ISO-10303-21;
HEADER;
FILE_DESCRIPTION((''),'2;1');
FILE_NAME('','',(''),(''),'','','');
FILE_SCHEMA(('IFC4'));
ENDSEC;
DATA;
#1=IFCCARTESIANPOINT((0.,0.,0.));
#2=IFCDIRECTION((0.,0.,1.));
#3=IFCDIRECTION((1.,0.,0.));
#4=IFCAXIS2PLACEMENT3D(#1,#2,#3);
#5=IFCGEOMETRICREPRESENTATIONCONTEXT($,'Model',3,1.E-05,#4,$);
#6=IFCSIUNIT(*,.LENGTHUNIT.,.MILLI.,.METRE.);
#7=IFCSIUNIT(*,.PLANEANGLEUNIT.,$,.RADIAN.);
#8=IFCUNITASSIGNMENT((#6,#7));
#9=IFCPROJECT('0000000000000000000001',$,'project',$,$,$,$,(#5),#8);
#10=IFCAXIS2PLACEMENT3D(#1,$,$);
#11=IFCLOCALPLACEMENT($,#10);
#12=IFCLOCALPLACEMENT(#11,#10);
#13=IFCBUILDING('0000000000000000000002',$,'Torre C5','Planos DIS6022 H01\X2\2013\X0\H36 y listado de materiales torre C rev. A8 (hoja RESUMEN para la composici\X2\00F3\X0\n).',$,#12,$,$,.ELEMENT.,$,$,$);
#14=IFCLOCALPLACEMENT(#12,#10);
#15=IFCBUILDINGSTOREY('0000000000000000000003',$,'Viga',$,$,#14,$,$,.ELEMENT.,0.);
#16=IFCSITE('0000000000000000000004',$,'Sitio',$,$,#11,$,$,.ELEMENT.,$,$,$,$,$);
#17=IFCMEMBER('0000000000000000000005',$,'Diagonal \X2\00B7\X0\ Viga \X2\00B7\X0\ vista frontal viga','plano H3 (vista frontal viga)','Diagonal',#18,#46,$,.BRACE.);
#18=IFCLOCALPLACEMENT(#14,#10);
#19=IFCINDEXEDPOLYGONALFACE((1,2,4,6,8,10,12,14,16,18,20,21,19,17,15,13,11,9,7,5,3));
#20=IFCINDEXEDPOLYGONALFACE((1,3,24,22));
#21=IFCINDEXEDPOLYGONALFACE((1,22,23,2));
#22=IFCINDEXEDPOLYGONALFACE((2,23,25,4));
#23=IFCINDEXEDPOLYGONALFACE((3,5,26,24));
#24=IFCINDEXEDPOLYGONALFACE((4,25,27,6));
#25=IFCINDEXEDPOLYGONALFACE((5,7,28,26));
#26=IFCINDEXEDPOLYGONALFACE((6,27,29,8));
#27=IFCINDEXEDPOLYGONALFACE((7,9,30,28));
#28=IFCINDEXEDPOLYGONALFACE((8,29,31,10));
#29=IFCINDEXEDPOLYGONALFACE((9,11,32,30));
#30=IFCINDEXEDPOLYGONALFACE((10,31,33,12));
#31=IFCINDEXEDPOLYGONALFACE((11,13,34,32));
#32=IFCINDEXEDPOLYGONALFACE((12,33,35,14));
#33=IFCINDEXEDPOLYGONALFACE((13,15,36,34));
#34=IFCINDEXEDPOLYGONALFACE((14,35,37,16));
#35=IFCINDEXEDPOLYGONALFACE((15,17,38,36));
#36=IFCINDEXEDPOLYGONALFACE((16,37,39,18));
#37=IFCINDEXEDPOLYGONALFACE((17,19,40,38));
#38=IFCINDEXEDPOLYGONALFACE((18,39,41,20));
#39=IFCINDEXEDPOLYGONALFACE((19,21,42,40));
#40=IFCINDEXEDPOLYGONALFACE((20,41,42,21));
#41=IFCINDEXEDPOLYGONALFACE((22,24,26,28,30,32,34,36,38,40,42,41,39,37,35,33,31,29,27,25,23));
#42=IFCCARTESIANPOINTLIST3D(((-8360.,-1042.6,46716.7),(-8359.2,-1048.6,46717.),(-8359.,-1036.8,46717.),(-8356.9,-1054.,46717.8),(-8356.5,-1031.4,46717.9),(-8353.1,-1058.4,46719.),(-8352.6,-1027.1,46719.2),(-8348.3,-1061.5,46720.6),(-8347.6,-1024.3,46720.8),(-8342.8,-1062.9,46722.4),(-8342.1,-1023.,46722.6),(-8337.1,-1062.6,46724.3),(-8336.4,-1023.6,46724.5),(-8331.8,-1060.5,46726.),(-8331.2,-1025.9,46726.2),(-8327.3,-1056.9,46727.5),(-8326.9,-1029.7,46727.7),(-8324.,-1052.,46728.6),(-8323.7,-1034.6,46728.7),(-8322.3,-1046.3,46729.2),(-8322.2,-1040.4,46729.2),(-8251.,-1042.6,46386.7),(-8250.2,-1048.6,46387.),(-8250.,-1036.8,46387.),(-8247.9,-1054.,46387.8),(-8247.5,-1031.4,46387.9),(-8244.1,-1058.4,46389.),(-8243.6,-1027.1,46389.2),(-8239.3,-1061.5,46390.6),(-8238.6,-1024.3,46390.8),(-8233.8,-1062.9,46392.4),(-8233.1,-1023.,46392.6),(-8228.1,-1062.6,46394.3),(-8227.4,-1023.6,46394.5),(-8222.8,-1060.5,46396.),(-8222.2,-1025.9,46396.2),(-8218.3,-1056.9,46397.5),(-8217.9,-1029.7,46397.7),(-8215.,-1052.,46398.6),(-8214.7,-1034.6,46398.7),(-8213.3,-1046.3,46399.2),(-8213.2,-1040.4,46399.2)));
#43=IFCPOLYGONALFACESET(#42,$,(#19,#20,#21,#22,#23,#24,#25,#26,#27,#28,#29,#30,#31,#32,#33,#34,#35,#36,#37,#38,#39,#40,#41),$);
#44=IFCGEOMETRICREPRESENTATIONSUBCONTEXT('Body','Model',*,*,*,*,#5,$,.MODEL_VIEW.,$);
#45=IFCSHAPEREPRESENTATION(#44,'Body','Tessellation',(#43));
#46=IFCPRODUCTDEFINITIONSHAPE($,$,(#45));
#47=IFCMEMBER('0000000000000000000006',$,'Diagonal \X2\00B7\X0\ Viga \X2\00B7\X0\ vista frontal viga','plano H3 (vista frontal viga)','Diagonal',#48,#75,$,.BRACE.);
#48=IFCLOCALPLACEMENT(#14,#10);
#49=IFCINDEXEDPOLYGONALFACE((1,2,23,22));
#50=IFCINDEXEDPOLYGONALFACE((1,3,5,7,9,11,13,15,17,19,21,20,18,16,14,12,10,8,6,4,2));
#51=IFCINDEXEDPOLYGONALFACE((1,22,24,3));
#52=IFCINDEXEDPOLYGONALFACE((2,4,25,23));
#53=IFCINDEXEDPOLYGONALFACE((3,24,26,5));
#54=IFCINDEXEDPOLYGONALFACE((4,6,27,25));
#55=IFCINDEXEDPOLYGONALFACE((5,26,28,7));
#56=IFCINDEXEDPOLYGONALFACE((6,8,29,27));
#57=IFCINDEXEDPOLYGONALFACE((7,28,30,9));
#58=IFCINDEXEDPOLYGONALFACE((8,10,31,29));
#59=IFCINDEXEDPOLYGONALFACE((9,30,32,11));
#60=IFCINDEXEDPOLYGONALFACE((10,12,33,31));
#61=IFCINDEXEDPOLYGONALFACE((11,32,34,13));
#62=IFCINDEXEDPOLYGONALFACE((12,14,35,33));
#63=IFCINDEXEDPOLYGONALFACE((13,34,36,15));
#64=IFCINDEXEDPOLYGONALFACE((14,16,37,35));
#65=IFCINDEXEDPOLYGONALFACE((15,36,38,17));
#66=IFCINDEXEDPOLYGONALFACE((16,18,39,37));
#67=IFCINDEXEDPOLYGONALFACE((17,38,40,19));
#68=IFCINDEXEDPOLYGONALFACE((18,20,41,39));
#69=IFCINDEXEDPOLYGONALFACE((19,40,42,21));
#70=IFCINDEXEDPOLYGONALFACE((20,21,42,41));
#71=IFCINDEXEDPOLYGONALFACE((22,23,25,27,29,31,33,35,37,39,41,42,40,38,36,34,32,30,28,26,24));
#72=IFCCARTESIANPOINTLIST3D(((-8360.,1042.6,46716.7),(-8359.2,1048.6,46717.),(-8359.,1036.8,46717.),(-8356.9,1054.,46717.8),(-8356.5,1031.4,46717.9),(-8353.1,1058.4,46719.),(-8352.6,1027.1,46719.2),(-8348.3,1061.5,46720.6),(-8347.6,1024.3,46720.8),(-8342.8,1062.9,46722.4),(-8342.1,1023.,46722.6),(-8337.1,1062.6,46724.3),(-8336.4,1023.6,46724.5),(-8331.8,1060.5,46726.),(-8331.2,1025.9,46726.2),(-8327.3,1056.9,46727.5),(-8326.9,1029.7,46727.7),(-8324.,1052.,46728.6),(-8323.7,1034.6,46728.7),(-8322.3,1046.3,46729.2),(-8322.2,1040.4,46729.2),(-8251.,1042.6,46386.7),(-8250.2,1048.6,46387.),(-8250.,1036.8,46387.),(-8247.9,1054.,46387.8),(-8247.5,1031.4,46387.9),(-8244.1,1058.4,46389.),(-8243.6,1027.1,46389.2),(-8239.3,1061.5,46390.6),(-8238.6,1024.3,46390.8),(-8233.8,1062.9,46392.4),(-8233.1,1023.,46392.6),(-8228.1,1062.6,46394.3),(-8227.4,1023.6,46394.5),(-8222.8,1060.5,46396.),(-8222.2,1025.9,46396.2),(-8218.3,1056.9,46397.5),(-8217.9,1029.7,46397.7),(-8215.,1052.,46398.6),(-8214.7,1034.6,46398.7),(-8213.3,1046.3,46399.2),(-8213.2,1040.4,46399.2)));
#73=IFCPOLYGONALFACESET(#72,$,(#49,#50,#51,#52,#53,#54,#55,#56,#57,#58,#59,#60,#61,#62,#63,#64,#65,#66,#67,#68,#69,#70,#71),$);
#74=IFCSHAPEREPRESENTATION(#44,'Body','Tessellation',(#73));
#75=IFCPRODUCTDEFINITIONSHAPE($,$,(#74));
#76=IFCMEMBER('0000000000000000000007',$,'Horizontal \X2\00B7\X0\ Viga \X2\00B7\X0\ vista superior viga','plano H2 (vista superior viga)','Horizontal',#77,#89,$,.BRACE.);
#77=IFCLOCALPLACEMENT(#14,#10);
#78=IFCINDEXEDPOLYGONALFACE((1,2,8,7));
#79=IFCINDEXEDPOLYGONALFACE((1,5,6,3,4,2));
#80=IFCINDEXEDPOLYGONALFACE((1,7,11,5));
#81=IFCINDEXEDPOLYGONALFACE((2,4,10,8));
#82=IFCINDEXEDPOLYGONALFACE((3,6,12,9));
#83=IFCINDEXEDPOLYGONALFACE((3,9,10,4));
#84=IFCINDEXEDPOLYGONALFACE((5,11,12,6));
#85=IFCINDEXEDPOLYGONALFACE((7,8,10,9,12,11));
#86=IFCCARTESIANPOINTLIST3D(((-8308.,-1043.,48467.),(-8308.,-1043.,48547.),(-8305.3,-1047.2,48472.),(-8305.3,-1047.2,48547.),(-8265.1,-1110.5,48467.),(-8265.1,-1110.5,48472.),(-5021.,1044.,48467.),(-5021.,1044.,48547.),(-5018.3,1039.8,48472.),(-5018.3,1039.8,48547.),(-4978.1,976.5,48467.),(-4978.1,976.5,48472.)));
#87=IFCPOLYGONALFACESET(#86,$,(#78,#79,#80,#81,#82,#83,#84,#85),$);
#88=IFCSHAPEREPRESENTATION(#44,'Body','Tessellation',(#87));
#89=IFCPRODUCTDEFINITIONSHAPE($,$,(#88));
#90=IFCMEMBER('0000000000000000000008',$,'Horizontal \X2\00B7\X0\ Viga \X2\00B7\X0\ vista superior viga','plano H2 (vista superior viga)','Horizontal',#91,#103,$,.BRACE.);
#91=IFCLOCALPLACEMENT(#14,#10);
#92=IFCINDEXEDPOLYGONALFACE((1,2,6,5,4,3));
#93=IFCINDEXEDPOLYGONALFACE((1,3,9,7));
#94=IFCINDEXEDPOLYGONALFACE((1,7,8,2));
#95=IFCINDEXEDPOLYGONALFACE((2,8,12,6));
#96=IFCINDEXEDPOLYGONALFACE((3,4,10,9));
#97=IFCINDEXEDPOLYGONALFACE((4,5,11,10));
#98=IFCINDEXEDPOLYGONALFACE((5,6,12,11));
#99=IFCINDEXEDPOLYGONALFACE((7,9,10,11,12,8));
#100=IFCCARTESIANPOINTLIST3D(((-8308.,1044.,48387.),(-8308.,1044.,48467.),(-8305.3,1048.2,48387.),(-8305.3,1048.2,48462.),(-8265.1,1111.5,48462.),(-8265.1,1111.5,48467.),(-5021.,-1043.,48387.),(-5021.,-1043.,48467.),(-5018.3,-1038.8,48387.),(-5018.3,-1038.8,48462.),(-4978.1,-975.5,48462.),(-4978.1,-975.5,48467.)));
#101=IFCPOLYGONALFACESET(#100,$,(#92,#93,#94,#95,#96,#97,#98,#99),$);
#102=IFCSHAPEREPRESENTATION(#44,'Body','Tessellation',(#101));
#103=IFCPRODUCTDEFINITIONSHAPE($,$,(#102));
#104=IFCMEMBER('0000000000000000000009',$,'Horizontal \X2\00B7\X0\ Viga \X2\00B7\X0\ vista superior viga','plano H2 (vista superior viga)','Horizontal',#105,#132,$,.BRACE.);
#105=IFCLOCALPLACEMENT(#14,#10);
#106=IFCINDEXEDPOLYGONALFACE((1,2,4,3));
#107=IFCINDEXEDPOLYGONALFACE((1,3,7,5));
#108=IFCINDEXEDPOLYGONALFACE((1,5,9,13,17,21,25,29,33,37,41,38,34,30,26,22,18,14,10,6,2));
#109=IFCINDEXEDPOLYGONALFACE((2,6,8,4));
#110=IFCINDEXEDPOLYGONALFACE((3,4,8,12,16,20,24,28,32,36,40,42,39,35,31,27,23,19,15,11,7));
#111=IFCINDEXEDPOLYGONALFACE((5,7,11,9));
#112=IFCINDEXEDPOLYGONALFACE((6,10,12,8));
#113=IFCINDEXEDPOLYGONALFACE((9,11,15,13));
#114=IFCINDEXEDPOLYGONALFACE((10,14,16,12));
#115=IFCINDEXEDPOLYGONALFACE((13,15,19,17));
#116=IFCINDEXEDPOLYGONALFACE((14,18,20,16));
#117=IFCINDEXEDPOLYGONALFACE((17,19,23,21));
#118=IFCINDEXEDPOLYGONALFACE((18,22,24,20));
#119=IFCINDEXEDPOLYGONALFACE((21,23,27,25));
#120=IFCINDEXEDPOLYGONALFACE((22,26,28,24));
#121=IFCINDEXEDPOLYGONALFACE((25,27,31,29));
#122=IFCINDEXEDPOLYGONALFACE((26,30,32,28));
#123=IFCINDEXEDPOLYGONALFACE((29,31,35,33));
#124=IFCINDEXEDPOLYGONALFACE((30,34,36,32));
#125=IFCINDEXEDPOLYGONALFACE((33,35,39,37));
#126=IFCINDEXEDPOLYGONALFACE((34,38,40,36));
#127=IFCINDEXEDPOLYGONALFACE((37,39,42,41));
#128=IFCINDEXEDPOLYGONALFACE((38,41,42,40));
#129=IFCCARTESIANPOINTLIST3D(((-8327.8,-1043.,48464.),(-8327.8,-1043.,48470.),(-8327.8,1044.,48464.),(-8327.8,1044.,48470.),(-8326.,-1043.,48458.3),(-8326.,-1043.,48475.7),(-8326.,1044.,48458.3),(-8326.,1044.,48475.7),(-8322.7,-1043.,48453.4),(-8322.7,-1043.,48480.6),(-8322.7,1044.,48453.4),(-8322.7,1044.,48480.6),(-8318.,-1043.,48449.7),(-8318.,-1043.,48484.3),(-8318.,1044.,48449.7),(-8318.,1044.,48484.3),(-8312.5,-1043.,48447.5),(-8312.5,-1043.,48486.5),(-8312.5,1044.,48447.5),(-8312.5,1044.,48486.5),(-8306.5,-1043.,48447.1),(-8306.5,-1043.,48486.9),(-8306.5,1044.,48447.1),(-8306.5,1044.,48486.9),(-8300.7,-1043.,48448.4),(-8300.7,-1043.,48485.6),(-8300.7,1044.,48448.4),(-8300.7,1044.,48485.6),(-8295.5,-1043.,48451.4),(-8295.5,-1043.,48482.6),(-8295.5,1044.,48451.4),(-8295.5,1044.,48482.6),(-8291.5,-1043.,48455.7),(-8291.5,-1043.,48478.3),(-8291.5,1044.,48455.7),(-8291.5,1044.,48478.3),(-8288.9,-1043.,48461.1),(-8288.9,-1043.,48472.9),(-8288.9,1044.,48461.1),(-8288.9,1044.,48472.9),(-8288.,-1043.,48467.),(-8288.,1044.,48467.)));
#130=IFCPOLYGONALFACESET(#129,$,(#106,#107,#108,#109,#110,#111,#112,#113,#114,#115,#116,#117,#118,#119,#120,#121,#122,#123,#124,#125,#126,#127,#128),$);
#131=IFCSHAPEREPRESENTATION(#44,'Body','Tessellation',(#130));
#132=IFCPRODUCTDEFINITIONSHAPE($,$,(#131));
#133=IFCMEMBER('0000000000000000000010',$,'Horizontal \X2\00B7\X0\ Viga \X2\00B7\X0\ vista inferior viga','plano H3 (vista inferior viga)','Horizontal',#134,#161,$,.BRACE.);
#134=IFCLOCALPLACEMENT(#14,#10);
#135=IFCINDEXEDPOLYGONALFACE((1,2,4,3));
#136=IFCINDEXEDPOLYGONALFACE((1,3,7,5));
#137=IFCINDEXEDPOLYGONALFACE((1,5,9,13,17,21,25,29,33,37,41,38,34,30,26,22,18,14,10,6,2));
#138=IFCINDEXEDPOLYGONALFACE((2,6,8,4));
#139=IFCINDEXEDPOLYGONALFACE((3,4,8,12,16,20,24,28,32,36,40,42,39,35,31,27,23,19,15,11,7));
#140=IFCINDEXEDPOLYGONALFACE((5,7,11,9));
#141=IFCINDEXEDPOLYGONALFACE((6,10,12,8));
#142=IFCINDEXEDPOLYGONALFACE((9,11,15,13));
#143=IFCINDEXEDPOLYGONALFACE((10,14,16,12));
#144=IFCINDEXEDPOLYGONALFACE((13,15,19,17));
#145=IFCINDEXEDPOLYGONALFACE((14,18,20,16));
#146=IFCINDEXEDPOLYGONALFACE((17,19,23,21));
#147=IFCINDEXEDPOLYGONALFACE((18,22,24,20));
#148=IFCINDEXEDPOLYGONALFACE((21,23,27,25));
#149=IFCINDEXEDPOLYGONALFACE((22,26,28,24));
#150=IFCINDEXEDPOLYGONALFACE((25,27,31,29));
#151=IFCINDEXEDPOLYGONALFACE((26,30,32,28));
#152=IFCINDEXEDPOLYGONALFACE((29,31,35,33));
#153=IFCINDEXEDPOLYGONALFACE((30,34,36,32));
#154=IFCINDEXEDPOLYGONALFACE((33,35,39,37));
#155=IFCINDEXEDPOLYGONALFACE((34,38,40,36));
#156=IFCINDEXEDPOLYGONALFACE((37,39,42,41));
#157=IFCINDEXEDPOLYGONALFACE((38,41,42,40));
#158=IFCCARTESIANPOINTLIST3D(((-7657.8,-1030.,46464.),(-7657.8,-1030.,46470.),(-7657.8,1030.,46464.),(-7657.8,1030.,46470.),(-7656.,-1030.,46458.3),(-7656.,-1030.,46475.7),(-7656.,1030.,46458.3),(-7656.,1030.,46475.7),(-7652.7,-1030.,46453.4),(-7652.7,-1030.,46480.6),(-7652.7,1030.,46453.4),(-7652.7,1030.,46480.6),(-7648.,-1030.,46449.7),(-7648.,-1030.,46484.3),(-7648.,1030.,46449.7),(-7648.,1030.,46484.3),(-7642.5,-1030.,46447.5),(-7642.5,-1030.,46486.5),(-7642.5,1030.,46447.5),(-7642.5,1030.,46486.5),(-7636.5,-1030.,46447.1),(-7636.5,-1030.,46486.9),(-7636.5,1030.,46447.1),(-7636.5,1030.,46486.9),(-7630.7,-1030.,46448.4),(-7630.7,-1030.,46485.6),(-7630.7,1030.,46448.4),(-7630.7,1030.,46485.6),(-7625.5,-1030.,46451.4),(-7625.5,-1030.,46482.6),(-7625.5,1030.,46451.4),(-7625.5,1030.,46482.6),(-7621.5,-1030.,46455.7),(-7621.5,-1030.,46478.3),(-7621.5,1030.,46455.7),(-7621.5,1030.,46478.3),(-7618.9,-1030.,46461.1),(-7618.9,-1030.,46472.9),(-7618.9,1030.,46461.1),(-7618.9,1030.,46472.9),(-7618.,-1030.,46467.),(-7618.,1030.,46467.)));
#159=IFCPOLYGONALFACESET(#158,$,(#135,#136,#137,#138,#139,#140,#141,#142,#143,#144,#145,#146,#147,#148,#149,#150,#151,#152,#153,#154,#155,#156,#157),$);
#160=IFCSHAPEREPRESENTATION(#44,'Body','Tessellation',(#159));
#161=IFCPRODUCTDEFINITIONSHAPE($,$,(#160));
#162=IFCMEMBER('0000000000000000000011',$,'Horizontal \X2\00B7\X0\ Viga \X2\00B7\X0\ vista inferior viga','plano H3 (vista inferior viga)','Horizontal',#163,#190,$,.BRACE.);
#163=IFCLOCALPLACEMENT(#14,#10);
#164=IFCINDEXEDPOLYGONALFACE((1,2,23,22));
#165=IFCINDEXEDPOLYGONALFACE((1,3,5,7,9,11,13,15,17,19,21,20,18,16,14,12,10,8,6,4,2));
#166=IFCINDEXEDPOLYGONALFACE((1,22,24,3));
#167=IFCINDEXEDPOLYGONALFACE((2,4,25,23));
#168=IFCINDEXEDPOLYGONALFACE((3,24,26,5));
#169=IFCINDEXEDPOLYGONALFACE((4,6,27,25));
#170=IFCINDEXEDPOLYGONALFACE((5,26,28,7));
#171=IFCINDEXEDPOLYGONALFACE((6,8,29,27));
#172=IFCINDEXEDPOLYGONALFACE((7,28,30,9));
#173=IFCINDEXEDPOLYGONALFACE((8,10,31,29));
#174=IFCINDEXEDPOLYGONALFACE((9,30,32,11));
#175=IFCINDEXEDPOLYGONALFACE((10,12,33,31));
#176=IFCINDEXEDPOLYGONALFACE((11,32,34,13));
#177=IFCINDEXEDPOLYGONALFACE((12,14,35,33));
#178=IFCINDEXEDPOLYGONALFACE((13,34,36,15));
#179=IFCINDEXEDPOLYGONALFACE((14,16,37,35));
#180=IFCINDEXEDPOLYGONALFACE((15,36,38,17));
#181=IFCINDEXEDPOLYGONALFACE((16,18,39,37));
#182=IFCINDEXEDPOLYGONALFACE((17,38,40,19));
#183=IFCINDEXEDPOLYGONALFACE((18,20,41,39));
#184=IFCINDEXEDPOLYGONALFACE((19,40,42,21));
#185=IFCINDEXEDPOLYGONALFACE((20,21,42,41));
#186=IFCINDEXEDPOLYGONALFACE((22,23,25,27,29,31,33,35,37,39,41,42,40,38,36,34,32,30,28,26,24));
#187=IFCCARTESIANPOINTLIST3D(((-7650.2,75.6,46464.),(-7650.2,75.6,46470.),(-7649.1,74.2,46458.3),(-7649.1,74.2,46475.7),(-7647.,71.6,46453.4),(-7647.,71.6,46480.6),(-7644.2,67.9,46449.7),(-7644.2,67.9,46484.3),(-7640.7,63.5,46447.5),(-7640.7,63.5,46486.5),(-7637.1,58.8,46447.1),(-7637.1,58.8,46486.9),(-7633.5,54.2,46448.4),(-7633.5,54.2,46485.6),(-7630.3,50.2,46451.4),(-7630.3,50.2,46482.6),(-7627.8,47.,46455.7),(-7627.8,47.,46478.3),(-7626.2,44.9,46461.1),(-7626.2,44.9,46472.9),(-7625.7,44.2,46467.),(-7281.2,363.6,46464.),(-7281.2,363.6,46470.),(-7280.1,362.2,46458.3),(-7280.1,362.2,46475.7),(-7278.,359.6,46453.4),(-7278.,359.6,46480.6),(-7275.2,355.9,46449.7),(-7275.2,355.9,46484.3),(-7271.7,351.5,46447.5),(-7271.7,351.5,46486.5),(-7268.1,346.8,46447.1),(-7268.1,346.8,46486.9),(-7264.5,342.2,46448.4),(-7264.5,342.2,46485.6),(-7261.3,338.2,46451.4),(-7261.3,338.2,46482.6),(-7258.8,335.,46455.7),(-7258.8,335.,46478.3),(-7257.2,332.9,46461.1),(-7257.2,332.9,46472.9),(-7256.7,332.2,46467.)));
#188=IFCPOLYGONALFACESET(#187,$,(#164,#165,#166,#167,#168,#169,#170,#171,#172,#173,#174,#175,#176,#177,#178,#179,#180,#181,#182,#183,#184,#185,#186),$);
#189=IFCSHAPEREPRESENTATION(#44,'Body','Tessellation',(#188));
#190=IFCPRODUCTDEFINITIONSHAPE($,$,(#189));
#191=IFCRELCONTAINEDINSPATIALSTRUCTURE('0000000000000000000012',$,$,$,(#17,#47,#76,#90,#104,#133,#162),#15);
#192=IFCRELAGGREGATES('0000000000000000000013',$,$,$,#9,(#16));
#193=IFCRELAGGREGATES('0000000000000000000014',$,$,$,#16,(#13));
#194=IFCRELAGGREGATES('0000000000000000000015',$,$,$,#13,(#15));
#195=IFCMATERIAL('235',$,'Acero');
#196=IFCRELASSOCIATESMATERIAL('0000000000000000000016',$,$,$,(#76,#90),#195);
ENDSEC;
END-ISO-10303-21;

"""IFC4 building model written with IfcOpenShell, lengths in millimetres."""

from ifc_helpers import new_model, si_unit, frame, frame_2d, origin, origin_with_axes, place, context, subcontext, project, spatial, circle, l_section, extrude, material, element, save


model = new_model("IFC4")

# Units and contexts
model_context = context("Model", 3, precision=1e-05, world=origin_with_axes())
body_context = subcontext(model_context, "Body", "Model", "MODEL_VIEW")
ifc_project = project(units=[si_unit("LENGTHUNIT", "METRE", prefix="MILLI"), si_unit("PLANEANGLEUNIT", "RADIAN")], contexts=[model_context])

# Site, building, storey
site_placement = place(None, origin())
site = spatial("IfcSite", under=ifc_project, at=site_placement, Name="Sitio", CompositionType="ELEMENT")
building_placement = place(site_placement, origin())
building = spatial("IfcBuilding", under=site, at=building_placement, Name="Torre C5", Description="Planos DIS6022 H01–H36 y listado de materiales torre C rev. A8 (hoja RESUMEN para la composición).", CompositionType="ELEMENT")
storey_placement = place(building_placement, origin())
storey = spatial("IfcBuildingStorey", under=building, at=storey_placement, Name="Viga", CompositionType="ELEMENT", Elevation=0.0)

# Members
ifc_material_1 = material(Name="235", Category="Acero")
for number, where, z_axis, x_axis, name in (
    (1, (-8232.0, -1043.0, 46393.0), (-0.313637, 0.0, 0.949543), (0.941309, 0.131406, 0.310917), "Diagonal · Viga · vista frontal viga"),
    (2, (-8232.0, 1043.0, 46393.0), (-0.313637, 0.0, 0.949543), (0.941309, -0.131406, 0.310917), "Diagonal · Viga · vista frontal viga"),
):
    element("IfcMember", number, at=place(storey_placement, frame(where, z_axis=z_axis, x_axis=x_axis)), inside=storey, Name=name, Description="plano H3 (vista frontal viga)", ObjectType="Diagonal", PredefinedType="BRACE", context=body_context, shape_type="SweptSolid", body=[
        extrude(circle(Radius=20.0), None, (0.0, 0.0, 1.0), 347.5),
    ])
for number, where, z_axis, x_axis, name in (
    (3, (-5021.0, 1044.0, 48467.0), (-0.844211, -0.536011, 0.0), (0.536011, -0.844211, 0.0), "Horizontal · Viga · vista superior viga"),
    (4, (-5021.0, -1043.0, 48467.0), (-0.844211, 0.536011, 0.0), (0.536011, 0.844211, 0.0), "Horizontal · Viga · vista superior viga"),
):
    element("IfcMember", number, at=place(storey_placement, frame(where, z_axis=z_axis, x_axis=x_axis)), inside=storey, material=ifc_material_1, Name=name, Description="plano H2 (vista superior viga)", ObjectType="Horizontal", PredefinedType="BRACE", context=body_context, shape_type="SweptSolid", body=[
        extrude(l_section(Depth=80.0, Width=80.0, Thickness=5.0, at=frame_2d((40.0, 40.0))), None, (0.0, 0.0, 1.0), 3893.6),
    ])
member_1_placement = place(storey_placement, frame((-8308.0, -1043.0, 48467.0), z_axis=(0.0, 1.0, 0.0), x_axis=(1.0, 0.0, 0.0)))
element("IfcMember", 5, at=member_1_placement, inside=storey, Name="Horizontal · Viga · vista superior viga", Description="plano H2 (vista superior viga)", ObjectType="Horizontal", PredefinedType="BRACE", context=body_context, shape_type="SweptSolid", body=[
    extrude(circle(Radius=20.0), None, (0.0, 0.0, 1.0), 2087.0),
])
member_2_placement = place(storey_placement, frame((-7638.0, 1030.0, 46467.0), z_axis=(0.0, -1.0, 0.0), x_axis=(1.0, 0.0, 0.0)))
element("IfcMember", 6, at=member_2_placement, inside=storey, Name="Horizontal · Viga · vista inferior viga", Description="plano H3 (vista inferior viga)", ObjectType="Horizontal", PredefinedType="BRACE", context=body_context, shape_type="SweptSolid", body=[
    extrude(circle(Radius=20.0), None, (0.0, 0.0, 1.0), 2060.0),
])
member_3_placement = place(storey_placement, frame((-7638.0, 60.0, 46467.0), z_axis=(0.788316, 0.615271, 0.0), x_axis=(0.615271, -0.788316, 0.0)))
element("IfcMember", 7, at=member_3_placement, inside=storey, Name="Horizontal · Viga · vista inferior viga", Description="plano H3 (vista inferior viga)", ObjectType="Horizontal", PredefinedType="BRACE", context=body_context, shape_type="SweptSolid", body=[
    extrude(circle(Radius=20.0), None, (0.0, 0.0, 1.0), 468.1),
])

save(model, "model.ifc")
